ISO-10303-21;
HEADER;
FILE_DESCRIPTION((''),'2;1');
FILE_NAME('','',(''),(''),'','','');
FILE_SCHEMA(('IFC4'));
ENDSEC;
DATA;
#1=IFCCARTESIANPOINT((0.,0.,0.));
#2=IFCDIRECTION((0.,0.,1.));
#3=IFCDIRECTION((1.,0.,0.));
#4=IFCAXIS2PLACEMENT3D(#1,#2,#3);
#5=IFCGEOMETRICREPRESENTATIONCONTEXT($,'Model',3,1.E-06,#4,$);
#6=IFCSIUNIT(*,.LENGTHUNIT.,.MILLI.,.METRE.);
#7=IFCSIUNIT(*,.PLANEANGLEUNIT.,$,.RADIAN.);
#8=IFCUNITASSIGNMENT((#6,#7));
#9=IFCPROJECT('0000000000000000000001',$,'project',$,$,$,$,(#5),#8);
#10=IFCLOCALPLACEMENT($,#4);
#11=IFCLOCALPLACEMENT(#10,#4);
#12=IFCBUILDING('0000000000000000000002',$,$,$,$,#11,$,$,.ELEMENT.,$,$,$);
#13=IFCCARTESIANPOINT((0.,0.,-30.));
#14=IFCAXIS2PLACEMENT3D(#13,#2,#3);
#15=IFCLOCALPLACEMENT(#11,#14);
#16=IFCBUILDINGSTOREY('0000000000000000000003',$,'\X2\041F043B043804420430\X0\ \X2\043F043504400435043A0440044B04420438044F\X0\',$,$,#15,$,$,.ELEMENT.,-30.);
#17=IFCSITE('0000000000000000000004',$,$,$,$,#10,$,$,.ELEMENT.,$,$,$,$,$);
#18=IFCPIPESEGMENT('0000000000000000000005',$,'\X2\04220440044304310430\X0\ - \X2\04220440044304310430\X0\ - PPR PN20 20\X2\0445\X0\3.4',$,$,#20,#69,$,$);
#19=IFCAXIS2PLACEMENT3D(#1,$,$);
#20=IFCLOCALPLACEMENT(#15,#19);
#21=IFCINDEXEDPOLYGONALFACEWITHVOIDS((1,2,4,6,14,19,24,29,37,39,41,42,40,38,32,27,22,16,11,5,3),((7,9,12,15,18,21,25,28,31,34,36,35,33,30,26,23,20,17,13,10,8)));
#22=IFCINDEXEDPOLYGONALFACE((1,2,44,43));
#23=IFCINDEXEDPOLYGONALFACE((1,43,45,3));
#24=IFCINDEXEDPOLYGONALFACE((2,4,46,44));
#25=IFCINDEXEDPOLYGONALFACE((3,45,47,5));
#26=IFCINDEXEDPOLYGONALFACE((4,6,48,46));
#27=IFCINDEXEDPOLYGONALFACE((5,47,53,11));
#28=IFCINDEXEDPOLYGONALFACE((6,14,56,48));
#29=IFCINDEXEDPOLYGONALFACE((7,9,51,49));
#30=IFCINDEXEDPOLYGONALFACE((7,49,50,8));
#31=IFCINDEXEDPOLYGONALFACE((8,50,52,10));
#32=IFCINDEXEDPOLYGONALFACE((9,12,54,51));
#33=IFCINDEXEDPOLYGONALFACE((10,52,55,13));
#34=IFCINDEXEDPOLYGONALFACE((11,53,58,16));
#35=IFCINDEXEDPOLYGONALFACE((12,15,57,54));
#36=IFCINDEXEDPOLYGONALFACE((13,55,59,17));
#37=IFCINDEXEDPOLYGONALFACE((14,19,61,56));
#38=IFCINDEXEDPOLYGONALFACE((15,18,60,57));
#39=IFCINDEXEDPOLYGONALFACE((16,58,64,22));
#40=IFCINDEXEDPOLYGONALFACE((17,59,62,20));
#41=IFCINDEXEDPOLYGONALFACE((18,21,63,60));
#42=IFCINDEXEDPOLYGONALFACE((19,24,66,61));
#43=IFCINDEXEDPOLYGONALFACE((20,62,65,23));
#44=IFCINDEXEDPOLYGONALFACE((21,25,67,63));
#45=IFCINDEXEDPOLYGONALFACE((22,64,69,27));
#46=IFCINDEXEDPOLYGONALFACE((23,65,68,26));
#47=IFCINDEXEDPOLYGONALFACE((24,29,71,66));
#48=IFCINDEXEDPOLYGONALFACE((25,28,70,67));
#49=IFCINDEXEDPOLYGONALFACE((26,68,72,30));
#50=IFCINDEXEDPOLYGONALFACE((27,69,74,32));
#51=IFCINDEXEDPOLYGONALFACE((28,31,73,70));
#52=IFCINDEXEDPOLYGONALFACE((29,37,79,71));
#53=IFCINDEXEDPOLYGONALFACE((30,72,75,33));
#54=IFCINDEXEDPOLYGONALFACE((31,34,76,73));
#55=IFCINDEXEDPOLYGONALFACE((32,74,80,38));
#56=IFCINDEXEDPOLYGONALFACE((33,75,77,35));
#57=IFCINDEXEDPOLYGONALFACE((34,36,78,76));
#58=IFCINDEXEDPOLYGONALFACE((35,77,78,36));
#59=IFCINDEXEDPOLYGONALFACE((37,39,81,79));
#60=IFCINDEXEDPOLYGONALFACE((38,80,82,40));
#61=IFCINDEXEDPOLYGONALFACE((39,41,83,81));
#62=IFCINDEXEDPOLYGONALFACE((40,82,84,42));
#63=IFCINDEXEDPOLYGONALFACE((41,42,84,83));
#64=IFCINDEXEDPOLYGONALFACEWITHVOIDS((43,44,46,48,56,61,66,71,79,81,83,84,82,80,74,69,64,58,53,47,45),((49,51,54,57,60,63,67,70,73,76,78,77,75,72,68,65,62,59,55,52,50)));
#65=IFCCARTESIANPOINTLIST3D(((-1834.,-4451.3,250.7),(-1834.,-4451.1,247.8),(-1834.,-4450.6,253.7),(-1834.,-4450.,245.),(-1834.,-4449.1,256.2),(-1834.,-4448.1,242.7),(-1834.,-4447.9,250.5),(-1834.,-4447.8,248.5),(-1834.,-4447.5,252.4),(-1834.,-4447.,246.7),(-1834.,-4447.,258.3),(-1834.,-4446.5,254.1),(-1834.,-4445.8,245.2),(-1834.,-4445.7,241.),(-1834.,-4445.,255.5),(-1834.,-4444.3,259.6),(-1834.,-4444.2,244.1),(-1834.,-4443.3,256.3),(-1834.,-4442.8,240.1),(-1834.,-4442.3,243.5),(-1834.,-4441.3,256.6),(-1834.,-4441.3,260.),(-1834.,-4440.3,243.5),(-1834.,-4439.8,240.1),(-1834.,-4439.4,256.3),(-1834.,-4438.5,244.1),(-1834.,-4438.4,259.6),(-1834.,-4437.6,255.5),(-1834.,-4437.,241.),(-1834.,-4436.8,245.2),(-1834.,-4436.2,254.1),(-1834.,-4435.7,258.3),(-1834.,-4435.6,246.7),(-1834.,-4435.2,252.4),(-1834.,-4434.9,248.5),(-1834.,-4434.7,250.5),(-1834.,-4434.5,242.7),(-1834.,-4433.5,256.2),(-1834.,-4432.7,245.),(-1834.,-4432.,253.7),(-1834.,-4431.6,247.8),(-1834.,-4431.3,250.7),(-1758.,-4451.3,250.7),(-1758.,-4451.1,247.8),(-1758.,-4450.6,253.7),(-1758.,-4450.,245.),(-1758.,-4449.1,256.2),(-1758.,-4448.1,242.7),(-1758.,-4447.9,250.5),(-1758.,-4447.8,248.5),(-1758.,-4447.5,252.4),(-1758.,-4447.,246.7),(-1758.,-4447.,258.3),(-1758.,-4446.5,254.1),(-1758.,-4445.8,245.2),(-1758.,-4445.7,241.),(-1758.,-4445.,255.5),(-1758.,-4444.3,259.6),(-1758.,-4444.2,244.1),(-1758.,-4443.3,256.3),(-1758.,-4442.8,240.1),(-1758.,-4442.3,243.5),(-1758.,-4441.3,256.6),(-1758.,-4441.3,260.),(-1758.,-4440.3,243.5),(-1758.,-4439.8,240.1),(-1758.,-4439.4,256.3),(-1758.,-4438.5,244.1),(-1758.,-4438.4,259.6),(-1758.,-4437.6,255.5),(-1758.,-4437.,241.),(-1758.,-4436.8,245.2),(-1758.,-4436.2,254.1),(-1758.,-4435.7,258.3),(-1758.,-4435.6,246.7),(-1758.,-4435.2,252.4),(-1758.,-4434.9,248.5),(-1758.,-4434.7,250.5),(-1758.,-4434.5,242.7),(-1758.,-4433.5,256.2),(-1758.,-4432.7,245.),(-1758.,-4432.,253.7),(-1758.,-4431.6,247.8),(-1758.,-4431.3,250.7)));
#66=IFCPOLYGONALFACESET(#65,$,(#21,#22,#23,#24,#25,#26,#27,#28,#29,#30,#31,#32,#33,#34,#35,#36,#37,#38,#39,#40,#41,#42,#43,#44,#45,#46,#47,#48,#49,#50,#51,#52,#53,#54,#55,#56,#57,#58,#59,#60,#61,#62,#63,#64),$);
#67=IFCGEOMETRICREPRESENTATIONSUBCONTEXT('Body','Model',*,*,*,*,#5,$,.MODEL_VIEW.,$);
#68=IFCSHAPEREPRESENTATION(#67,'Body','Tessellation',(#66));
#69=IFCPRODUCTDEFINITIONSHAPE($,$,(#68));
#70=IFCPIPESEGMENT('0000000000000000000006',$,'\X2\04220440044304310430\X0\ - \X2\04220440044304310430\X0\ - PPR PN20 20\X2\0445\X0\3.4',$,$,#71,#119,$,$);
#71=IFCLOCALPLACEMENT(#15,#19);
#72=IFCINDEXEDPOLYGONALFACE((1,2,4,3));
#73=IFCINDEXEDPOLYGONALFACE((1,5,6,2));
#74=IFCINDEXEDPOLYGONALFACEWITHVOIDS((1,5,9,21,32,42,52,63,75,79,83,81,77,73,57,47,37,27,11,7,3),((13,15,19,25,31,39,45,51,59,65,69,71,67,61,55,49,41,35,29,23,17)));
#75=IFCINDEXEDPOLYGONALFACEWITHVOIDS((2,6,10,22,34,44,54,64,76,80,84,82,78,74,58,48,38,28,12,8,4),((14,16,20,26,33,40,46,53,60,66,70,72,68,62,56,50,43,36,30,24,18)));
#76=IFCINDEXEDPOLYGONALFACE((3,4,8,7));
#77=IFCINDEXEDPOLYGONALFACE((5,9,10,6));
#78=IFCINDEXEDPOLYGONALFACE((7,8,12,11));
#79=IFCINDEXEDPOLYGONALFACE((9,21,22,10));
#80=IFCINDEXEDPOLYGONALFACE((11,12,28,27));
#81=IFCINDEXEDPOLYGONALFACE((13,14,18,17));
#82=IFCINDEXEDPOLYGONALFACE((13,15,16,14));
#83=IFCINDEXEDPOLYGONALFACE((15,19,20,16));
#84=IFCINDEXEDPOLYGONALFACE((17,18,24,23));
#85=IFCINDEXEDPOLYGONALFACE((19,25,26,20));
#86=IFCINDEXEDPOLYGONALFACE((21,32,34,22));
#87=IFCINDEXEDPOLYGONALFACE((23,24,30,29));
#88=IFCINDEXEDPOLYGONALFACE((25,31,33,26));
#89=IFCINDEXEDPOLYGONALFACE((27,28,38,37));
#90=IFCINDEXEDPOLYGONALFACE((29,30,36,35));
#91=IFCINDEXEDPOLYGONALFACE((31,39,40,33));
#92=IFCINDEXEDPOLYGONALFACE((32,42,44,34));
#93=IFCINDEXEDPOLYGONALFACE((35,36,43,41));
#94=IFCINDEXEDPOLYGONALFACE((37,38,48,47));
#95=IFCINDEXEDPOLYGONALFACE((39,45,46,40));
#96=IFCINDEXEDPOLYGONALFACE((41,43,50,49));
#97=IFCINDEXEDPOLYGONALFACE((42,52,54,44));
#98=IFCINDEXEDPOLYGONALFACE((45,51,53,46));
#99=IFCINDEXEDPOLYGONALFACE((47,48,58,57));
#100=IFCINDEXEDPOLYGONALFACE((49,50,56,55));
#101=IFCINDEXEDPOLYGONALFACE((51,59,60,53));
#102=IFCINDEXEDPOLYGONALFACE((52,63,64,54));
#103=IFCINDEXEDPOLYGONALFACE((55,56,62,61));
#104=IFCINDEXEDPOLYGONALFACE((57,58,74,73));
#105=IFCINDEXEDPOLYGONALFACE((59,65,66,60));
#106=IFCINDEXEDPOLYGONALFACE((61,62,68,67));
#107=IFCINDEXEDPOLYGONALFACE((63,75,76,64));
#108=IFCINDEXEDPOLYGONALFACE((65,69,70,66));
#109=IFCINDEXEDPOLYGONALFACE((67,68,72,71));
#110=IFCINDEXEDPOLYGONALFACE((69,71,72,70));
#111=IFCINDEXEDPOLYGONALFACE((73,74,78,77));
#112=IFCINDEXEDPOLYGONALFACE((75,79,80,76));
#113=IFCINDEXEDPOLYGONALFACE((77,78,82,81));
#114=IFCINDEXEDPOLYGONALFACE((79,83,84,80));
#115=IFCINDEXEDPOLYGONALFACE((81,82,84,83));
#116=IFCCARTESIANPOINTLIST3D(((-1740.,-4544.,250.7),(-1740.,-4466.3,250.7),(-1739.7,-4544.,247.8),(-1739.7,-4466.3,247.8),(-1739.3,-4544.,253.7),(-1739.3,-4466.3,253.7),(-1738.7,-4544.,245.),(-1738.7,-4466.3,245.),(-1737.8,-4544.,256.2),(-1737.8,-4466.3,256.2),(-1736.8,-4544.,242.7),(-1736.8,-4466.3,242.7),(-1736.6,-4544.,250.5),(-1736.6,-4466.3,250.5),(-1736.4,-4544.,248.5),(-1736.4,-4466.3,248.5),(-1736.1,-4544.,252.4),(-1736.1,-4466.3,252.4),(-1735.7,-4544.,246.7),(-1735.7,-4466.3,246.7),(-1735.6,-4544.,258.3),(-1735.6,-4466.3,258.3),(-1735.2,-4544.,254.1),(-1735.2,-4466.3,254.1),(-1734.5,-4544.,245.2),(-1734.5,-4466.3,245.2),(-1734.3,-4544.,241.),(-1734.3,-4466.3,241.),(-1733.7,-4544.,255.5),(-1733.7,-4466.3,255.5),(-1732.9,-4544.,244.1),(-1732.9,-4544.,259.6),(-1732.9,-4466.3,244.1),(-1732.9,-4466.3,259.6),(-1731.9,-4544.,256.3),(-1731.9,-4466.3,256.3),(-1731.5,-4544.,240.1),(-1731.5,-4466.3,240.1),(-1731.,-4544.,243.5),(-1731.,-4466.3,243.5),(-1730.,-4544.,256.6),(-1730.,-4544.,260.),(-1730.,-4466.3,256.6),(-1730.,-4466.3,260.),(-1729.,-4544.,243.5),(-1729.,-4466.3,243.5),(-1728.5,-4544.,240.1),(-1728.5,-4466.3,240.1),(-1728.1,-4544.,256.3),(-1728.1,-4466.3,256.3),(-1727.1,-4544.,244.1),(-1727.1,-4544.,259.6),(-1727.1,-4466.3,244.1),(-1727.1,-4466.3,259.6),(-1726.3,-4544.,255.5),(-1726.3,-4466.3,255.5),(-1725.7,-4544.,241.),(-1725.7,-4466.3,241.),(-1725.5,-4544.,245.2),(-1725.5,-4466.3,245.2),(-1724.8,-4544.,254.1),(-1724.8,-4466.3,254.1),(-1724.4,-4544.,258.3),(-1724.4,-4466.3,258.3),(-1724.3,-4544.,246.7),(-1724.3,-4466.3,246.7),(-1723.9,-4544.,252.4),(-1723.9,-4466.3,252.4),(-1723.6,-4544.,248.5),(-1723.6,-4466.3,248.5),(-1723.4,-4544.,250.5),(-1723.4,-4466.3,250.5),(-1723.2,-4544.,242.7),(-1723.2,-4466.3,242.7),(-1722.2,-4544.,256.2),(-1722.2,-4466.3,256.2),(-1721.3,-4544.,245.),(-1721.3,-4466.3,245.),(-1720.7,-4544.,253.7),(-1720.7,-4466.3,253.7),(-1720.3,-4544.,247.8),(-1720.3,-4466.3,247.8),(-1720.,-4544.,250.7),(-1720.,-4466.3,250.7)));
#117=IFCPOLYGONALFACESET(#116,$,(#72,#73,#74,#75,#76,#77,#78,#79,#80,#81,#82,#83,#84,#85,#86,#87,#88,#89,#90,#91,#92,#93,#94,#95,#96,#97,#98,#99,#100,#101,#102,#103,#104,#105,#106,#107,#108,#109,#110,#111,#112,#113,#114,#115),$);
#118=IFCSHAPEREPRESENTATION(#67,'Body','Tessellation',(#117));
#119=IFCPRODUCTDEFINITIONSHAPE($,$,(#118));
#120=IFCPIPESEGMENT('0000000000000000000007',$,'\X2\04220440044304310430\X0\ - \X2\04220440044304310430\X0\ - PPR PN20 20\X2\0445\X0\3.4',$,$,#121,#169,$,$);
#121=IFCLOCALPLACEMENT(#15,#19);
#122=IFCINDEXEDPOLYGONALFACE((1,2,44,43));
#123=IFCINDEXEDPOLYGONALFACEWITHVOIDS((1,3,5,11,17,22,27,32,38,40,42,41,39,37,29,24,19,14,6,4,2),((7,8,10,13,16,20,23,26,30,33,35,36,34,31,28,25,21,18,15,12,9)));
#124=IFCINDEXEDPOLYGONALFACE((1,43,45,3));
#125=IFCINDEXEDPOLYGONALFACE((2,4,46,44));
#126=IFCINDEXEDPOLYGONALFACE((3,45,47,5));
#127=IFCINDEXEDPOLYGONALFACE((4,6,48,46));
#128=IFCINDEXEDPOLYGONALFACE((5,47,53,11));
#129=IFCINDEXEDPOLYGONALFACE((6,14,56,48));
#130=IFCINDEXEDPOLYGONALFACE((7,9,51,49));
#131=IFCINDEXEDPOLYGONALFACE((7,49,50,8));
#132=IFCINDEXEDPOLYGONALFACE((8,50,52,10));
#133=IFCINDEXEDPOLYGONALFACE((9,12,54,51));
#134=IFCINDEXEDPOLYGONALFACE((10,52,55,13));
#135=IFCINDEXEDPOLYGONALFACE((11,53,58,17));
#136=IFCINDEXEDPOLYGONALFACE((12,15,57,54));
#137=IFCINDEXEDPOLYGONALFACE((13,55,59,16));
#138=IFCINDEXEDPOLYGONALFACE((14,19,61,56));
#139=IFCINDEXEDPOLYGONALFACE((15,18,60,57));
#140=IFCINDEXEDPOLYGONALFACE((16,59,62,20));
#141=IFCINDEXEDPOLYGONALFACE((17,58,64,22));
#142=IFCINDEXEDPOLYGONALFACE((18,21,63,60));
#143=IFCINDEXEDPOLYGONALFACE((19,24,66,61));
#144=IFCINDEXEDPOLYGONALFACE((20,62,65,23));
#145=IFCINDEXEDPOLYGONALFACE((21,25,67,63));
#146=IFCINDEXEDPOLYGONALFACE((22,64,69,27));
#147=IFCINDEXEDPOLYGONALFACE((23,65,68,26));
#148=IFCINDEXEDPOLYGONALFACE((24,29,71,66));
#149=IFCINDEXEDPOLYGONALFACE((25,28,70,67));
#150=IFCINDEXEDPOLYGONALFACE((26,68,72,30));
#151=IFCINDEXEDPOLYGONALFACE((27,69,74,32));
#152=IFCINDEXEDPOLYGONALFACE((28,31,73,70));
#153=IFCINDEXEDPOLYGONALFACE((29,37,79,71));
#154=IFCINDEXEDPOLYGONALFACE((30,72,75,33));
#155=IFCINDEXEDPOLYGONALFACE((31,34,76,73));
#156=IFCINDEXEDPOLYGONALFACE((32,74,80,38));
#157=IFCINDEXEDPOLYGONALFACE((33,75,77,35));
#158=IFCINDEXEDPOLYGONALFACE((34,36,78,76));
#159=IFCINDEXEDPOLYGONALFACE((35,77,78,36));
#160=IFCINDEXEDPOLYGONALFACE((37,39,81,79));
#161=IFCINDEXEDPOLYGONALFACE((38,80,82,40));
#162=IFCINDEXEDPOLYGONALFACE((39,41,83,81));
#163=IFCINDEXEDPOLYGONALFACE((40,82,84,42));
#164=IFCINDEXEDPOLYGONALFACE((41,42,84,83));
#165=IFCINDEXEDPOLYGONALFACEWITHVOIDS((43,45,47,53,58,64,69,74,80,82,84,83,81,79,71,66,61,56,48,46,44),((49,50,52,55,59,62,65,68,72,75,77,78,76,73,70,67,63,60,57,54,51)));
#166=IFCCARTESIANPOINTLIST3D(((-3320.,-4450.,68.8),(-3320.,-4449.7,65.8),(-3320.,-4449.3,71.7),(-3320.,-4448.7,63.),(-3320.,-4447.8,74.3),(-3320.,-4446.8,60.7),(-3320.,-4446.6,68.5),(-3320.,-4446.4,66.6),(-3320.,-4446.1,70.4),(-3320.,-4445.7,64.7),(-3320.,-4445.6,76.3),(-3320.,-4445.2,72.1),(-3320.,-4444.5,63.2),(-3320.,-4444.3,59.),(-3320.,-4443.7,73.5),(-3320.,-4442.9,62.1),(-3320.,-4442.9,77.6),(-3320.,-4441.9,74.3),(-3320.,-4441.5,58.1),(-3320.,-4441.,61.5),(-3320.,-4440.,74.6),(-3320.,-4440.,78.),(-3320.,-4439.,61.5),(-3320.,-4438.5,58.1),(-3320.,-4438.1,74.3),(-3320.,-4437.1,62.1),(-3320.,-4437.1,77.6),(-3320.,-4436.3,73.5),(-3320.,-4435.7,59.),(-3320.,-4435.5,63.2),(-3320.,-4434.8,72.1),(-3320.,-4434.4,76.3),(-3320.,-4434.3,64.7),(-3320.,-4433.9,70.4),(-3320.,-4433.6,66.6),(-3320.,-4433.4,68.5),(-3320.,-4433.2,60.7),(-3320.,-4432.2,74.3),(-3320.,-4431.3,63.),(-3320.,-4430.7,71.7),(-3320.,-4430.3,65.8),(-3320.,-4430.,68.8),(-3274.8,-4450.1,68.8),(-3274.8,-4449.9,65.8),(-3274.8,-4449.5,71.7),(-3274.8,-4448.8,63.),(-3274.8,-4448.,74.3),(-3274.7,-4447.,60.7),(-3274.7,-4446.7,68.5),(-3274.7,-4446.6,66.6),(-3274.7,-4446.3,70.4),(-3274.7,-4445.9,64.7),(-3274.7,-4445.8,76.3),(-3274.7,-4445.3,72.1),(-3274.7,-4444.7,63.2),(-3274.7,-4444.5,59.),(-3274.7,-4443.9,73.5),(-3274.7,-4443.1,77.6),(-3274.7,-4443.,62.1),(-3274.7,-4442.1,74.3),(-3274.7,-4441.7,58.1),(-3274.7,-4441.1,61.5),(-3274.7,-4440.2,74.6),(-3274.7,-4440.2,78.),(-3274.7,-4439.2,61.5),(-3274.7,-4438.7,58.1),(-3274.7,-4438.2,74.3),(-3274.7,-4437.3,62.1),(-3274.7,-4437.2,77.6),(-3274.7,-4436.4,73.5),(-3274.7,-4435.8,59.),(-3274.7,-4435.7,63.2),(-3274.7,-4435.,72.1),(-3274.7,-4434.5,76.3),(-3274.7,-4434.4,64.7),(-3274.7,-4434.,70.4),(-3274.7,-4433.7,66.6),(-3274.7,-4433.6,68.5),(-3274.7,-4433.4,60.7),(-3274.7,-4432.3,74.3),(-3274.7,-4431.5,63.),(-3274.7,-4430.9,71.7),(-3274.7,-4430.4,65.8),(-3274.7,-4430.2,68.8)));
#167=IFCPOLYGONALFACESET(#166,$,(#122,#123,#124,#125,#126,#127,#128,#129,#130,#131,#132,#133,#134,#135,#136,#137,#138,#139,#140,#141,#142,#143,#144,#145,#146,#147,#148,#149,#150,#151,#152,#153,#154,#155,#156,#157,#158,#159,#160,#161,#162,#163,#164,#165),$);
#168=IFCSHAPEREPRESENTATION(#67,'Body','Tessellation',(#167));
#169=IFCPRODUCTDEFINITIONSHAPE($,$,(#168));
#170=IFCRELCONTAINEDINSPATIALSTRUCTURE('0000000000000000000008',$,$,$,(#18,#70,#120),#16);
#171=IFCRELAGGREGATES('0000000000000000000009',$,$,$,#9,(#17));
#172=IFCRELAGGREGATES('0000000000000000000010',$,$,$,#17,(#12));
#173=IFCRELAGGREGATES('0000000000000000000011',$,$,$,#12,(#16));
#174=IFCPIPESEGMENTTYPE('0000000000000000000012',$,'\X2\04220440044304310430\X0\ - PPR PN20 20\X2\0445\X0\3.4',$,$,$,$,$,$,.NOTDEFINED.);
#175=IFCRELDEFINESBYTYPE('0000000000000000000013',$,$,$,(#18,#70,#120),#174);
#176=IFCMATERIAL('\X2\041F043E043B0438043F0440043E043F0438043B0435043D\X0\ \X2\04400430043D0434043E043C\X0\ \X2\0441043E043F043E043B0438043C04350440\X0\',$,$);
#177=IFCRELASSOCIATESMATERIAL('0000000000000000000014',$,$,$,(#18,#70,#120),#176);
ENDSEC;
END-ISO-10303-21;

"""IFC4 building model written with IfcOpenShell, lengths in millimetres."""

from ifc_helpers import new_model, entity, si_unit, frame, origin_with_axes, place, context, subcontext, project, spatial, material, type_object, element, save


model = new_model("IFC4")

# Units and contexts
model_context = context("Model", 3, precision=1e-06, world=origin_with_axes())
body_context = subcontext(model_context, "Body", "Model", "MODEL_VIEW")
ifc_project = project(units=[si_unit("LENGTHUNIT", "METRE", prefix="MILLI"), si_unit("PLANEANGLEUNIT", "RADIAN")], contexts=[model_context])

# Site, building, storey
site_placement = place(None, origin_with_axes())
site = spatial("IfcSite", under=ifc_project, at=site_placement, CompositionType="ELEMENT")
building_placement = place(site_placement, origin_with_axes())
building = spatial("IfcBuilding", under=site, at=building_placement, CompositionType="ELEMENT")
storey_placement = place(building_placement, frame((0.0, 0.0, -30.0), z_axis=(0.0, 0.0, 1.0), x_axis=(1.0, 0.0, 0.0)))
storey = spatial("IfcBuildingStorey", under=building, at=storey_placement, Name="Плита перекрытия", CompositionType="ELEMENT", Elevation=-30.0)

# Pipe segments
ifc_material_1 = material(Name="Полипропилен рандом сополимер")
pipe_segment_type_1 = type_object("IfcPipeSegmentType", Name="Труба - PPR PN20 20х3.4", PredefinedType="NOTDEFINED")
pipe_segment_1_placement = place(storey_placement, frame((-1834.0, -4441.3, 250.0), z_axis=(0.0, 0.0, 1.0), x_axis=(1.0, 0.0, 0.0)))
element("IfcPipeSegment", 1, at=pipe_segment_1_placement, inside=storey, type_object=pipe_segment_type_1, material=ifc_material_1, Name="Труба - Труба - PPR PN20 20х3.4", context=body_context, shape_type="AdvancedSweptSolid", body=[
    entity("IfcSweptDiskSolid", entity("IfcIndexedPolyCurve", entity("IfcCartesianPointList3D", [[0.0, 0.0, 0.0], [76.0, 0.0, 0.0]]), [entity("IfcLineIndex", [1, 2])]), 10.0, 6.6),
])
pipe_segment_2_placement = place(storey_placement, frame((-1730.0, -4544.0, 250.0), z_axis=(0.0, 0.0, 1.0), x_axis=(0.0, 1.0, 0.0)))
element("IfcPipeSegment", 2, at=pipe_segment_2_placement, inside=storey, type_object=pipe_segment_type_1, material=ifc_material_1, Name="Труба - Труба - PPR PN20 20х3.4", context=body_context, shape_type="AdvancedSweptSolid", body=[
    entity("IfcSweptDiskSolid", entity("IfcIndexedPolyCurve", entity("IfcCartesianPointList3D", [[0.0, 0.0, 0.0], [77.7, 0.0, 0.0]]), [entity("IfcLineIndex", [1, 2])]), 10.0, 6.6),
])
pipe_segment_3_placement = place(storey_placement, frame((-3274.7, -4440.2, 68.0), z_axis=(0.0, 0.0, 1.0), x_axis=(-0.999993, 0.003657, 0.0)))
element("IfcPipeSegment", 3, at=pipe_segment_3_placement, inside=storey, type_object=pipe_segment_type_1, material=ifc_material_1, Name="Труба - Труба - PPR PN20 20х3.4", context=body_context, shape_type="AdvancedSweptSolid", body=[
    entity("IfcSweptDiskSolid", entity("IfcIndexedPolyCurve", entity("IfcCartesianPointList3D", [[0.0, 0.0, 0.0], [45.3, 0.0, 0.0]]), [entity("IfcLineIndex", [1, 2])]), 10.0, 6.6),
])

save(model, "model.ifc")
